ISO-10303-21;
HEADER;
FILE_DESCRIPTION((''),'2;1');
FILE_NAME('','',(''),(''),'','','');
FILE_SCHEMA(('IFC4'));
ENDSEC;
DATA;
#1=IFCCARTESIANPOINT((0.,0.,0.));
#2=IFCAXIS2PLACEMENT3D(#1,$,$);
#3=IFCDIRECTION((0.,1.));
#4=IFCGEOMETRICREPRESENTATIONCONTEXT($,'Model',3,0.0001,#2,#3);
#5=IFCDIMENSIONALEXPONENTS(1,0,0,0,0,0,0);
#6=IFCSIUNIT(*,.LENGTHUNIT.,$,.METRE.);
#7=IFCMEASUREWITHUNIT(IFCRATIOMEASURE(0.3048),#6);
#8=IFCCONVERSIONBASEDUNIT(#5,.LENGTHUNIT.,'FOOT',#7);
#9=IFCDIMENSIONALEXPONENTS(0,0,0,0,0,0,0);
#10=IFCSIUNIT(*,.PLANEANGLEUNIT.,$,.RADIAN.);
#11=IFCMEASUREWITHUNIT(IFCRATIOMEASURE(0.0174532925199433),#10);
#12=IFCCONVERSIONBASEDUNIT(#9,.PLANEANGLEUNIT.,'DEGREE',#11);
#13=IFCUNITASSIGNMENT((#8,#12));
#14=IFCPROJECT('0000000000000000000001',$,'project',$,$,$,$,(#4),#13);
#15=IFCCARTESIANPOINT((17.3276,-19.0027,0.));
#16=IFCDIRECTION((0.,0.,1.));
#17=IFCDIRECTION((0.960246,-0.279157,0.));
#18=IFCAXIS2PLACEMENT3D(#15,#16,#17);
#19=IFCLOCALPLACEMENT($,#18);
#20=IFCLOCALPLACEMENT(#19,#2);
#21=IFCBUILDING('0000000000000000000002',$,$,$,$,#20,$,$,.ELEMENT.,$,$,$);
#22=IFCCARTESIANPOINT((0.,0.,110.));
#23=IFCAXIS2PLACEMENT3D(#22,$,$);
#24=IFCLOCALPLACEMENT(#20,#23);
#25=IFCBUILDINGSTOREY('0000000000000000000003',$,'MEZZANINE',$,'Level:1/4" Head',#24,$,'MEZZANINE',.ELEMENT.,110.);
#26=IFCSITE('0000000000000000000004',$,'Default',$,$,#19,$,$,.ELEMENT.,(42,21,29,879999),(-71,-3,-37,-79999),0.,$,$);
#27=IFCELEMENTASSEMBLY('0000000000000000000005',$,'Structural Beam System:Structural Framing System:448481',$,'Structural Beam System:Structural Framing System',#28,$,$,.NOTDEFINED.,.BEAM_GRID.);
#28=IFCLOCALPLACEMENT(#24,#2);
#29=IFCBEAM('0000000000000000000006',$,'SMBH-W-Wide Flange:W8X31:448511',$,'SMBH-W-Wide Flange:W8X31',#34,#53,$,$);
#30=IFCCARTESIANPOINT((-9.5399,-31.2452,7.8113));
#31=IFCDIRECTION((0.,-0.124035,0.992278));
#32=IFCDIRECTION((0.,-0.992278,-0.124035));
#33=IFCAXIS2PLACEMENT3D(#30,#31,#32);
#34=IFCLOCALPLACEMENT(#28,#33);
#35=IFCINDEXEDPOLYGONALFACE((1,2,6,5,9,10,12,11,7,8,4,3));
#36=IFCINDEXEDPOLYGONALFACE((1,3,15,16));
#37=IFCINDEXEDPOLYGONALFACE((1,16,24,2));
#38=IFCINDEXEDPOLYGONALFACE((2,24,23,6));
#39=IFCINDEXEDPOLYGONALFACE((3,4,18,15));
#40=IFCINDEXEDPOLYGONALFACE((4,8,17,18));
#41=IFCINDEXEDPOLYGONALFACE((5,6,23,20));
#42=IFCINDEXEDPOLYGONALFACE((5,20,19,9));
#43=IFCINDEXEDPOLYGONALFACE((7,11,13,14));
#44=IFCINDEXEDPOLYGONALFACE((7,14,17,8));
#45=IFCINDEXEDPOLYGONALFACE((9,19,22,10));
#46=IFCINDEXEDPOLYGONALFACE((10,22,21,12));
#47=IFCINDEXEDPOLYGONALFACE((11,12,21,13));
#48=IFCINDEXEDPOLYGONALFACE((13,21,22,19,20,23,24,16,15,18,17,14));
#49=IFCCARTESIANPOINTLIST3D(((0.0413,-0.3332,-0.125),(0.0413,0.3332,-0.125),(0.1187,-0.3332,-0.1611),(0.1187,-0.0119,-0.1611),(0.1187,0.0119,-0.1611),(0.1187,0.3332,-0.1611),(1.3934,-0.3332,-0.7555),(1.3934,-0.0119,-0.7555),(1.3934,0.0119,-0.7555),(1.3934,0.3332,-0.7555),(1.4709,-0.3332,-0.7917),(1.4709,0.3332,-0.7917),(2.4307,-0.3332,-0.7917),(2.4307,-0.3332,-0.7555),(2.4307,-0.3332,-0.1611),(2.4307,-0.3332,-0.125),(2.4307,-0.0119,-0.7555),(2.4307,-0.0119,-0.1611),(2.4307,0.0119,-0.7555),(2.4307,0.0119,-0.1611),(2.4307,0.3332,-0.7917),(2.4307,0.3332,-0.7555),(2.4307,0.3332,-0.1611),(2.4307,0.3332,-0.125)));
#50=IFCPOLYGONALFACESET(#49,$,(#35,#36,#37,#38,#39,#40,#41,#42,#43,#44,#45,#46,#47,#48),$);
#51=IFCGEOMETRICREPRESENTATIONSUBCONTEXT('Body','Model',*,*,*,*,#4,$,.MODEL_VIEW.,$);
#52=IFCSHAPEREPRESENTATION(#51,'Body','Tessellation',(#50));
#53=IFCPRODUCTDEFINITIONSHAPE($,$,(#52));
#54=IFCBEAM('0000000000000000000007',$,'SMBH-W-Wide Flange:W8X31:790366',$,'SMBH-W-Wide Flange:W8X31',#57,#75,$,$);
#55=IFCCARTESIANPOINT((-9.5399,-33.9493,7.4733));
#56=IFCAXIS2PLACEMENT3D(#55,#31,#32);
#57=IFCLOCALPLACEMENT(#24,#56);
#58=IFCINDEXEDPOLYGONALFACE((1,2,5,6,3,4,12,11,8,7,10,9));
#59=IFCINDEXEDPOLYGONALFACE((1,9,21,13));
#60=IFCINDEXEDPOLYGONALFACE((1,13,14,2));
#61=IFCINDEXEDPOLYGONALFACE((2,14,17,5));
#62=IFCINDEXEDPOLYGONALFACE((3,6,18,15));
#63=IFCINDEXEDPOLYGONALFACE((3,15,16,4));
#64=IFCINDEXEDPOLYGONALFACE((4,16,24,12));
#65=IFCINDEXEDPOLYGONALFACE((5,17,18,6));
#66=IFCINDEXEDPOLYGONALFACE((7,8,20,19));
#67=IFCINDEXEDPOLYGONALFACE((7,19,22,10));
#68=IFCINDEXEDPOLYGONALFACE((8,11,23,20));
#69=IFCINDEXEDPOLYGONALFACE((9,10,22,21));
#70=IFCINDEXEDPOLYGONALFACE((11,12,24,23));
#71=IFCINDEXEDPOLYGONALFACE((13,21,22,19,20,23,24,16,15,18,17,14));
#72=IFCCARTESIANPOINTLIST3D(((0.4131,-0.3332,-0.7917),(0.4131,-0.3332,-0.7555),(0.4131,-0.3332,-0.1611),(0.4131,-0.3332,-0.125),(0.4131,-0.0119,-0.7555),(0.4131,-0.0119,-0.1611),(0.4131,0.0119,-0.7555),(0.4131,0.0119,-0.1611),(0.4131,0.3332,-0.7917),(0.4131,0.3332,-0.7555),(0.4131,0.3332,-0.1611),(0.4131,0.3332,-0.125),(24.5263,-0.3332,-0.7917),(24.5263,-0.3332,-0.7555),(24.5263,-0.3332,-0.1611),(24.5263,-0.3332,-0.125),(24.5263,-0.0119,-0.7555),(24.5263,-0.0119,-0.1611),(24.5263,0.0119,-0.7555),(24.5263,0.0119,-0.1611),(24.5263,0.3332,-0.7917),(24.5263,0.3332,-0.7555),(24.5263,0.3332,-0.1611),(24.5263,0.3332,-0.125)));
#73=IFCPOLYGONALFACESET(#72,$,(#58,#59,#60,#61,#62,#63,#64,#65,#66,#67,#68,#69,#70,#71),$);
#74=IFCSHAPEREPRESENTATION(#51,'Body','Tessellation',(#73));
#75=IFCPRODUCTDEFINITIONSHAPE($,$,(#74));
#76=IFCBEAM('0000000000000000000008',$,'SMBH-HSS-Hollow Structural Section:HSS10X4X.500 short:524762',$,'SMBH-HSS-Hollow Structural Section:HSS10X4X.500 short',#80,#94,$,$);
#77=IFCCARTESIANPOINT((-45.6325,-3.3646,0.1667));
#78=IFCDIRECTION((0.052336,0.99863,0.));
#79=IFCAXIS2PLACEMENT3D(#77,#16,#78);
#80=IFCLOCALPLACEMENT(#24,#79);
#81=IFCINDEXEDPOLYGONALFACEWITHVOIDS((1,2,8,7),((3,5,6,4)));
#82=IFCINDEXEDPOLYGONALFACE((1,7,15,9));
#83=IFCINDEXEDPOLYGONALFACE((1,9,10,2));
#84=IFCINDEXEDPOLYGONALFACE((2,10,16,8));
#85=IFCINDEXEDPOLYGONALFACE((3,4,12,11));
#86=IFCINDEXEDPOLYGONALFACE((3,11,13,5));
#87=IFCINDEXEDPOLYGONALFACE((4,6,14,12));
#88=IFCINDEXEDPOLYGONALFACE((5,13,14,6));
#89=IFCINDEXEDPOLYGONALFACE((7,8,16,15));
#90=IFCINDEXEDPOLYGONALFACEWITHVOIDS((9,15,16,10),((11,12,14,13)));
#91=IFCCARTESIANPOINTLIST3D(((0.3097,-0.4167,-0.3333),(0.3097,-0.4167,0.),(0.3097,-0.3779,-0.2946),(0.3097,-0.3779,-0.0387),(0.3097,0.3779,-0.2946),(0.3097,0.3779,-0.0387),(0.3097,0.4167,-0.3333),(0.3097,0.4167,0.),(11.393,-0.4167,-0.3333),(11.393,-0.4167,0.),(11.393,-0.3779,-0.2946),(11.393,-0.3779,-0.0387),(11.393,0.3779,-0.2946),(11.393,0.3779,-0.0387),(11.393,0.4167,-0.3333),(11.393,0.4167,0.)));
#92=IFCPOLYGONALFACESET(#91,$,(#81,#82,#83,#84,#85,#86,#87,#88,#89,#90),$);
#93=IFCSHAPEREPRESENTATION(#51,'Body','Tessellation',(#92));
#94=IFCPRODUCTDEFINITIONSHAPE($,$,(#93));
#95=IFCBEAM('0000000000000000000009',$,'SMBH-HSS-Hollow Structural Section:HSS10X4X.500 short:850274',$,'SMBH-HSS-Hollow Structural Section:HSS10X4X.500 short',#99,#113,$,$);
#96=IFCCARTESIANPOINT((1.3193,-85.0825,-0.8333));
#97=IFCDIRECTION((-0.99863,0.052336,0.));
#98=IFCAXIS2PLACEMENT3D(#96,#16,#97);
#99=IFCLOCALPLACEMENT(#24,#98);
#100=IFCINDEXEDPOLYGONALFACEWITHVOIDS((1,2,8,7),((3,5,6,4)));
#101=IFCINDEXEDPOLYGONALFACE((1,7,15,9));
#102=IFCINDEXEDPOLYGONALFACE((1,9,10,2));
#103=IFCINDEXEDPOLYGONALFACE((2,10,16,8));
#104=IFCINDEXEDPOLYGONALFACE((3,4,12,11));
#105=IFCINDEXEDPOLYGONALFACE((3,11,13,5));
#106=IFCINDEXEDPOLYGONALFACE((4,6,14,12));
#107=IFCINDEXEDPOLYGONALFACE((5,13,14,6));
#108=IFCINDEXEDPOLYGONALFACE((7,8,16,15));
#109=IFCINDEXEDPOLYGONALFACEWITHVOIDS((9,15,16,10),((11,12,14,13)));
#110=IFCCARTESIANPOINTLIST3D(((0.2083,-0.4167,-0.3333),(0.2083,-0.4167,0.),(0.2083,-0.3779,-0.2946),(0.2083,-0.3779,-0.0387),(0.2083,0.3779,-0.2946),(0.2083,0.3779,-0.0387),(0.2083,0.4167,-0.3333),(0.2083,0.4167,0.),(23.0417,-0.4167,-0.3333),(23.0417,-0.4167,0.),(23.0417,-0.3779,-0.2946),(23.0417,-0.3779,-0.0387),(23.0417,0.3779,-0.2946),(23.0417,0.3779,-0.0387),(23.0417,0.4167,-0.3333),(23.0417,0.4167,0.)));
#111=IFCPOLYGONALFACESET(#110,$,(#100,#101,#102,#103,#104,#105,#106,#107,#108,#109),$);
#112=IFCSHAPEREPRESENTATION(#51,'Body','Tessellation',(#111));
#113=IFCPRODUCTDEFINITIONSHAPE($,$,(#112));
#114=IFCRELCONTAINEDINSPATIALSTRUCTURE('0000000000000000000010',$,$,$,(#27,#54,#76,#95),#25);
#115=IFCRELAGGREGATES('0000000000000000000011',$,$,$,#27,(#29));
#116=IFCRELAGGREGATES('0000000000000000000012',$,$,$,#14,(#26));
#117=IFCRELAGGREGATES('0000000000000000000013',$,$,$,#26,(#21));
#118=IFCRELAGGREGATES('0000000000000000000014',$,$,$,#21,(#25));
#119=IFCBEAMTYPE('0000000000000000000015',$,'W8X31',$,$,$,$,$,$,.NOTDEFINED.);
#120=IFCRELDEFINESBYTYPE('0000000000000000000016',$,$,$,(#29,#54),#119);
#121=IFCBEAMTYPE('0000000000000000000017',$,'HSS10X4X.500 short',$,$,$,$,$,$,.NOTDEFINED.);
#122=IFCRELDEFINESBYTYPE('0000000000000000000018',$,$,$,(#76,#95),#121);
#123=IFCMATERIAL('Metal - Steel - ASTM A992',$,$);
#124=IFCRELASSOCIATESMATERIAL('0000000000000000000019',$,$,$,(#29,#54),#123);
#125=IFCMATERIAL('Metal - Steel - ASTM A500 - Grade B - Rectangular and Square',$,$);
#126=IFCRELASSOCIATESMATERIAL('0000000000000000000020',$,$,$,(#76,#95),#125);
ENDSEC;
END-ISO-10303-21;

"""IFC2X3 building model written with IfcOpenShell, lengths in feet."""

from ifc_helpers import new_model, entity, si_unit, converted_unit, direction, frame, frame_2d, origin, place, context, subcontext, project, spatial, rectangle, i_section, extrude, boolean, clip, halfspace, material, type_object, element, aggregate, save


model = new_model("IFC2X3")

# Units and contexts
model_context = context("Model", 3, precision=0.0001, world=origin(), true_north=direction((0.0, 1.0)))
body_context = subcontext(model_context, "Body", "Model", "MODEL_VIEW")
ifc_project = project(units=[converted_unit("LENGTHUNIT", "FOOT", entity("IfcRatioMeasure", 0.3048), si_unit("LENGTHUNIT", "METRE"), dimensions=[1, 0, 0, 0, 0, 0, 0]), converted_unit("PLANEANGLEUNIT", "DEGREE", entity("IfcRatioMeasure", 0.0174532925199433), si_unit("PLANEANGLEUNIT", "RADIAN"), dimensions=[0, 0, 0, 0, 0, 0, 0])], contexts=[model_context])

# Site, building, storey
site_placement = place(None, frame((17.3276, -19.0027, 0.0), z_axis=(0.0, 0.0, 1.0), x_axis=(0.960246, -0.279157, 0.0)))
site = spatial("IfcSite", under=ifc_project, at=site_placement, Name="Default", CompositionType="ELEMENT", RefLatitude=(42, 21, 29, 879999), RefLongitude=(-71, -3, -37, -79999), RefElevation=0.0)
building_placement = place(site_placement, origin())
building = spatial("IfcBuilding", under=site, at=building_placement, CompositionType="ELEMENT")
storey_placement = place(building_placement, frame((0.0, 0.0, 110.0)))
storey = spatial("IfcBuildingStorey", under=building, at=storey_placement, Name="MEZZANINE", ObjectType="Level:1/4\" Head", LongName="MEZZANINE", CompositionType="ELEMENT", Elevation=110.0)

# Shared definitions
ifc_material_1 = material(Name="Metal - Steel - ASTM A500 - Grade B - Rectangular and Square")

# Element assembly, beam
assembly_1_placement = place(storey_placement, origin())
assembly_1 = element("IfcElementAssembly", 1, at=assembly_1_placement, inside=storey, Name="Structural Beam System:Structural Framing System:448481", ObjectType="Structural Beam System:Structural Framing System", AssemblyPlace="NOTDEFINED", PredefinedType="BEAM_GRID")
ifc_material_2 = material(Name="Metal - Steel - ASTM A992")
beam_type_1 = type_object("IfcBeamType", Name="W8X31", PredefinedType="NOTDEFINED")
beam_1_placement = place(assembly_1_placement, frame((-9.5399, -31.2452, 7.8113), z_axis=(0.0, -0.124035, 0.992278), x_axis=(0.0, -0.992278, -0.124035)))
beam_1 = element("IfcBeam", 2, at=beam_1_placement, type_object=beam_type_1, material=ifc_material_2, Name="SMBH-W-Wide Flange:W8X31:448511", ObjectType="SMBH-W-Wide Flange:W8X31", context=body_context, shape_type="SweptSolid", body=[
    clip(extrude(i_section(OverallWidth=0.6663, OverallDepth=0.6667, WebThickness=0.0238, FlangeThickness=0.0361, at=frame_2d((0.0, 0.0), x_axis=(0.0, 1.0))), frame((0.0413, 0.0, -0.4583), z_axis=(1.0, 0.0, 0.0), x_axis=(0.0, 0.0, -1.0)), (0.0, 0.0, 1.0), 2.3894), halfspace(frame((1.4709, -2.7251, -0.7917), z_axis=(-0.422618, 0.0, -0.906308), x_axis=(0.0, 1.0, 0.0)), False)),
])
aggregate(assembly_1, [beam_1])

# Beams
beam_2_placement = place(storey_placement, frame((-9.5399, -33.9493, 7.4733), z_axis=(0.0, -0.124035, 0.992278), x_axis=(0.0, -0.992278, -0.124035)))
element("IfcBeam", 3, at=beam_2_placement, inside=storey, type_object=beam_type_1, material=ifc_material_2, Name="SMBH-W-Wide Flange:W8X31:790366", ObjectType="SMBH-W-Wide Flange:W8X31", context=body_context, shape_type="SweptSolid", body=[
    extrude(i_section(OverallWidth=0.6663, OverallDepth=0.6667, WebThickness=0.0238, FlangeThickness=0.0361, at=frame_2d((0.0, 0.0), x_axis=(0.0, 1.0))), frame((0.4131, 0.0, -0.4583), z_axis=(1.0, 0.0, 0.0), x_axis=(0.0, 0.0, -1.0)), (0.0, 0.0, 1.0), 24.1132),
])
beam_type_2 = type_object("IfcBeamType", Name="HSS10X4X.500 short", PredefinedType="NOTDEFINED")
beam_3_placement = place(storey_placement, frame((-45.6325, -3.3646, 0.1667), z_axis=(0.0, 0.0, 1.0), x_axis=(0.052336, 0.99863, 0.0)))
element("IfcBeam", 4, at=beam_3_placement, inside=storey, type_object=beam_type_2, material=ifc_material_1, Name="SMBH-HSS-Hollow Structural Section:HSS10X4X.500 short:524762", ObjectType="SMBH-HSS-Hollow Structural Section:HSS10X4X.500 short", context=body_context, shape_type="SweptSolid", body=[
    boolean("DIFFERENCE", extrude(rectangle(XDim=0.3333, YDim=0.8333, at=frame_2d((0.0, 0.0), x_axis=(1.0, 0.0))), frame((0.3097, 0.0, -0.1667), z_axis=(1.0, 0.0, 0.0), x_axis=(0.0, 0.0, -1.0)), (0.0, 0.0, 1.0), 11.0833), extrude(rectangle(XDim=0.2559, YDim=0.7559, at=frame_2d((0.0, 0.0), x_axis=(0.0, 1.0))), frame((11.393, 0.0, -0.1667), z_axis=(-1.0, 0.0, 0.0), x_axis=(0.0, 1.0, 0.0)), (0.0, 0.0, 1.0), 11.0833)),
])
beam_4_placement = place(storey_placement, frame((1.3193, -85.0825, -0.8333), z_axis=(0.0, 0.0, 1.0), x_axis=(-0.99863, 0.052336, 0.0)))
element("IfcBeam", 5, at=beam_4_placement, inside=storey, type_object=beam_type_2, material=ifc_material_1, Name="SMBH-HSS-Hollow Structural Section:HSS10X4X.500 short:850274", ObjectType="SMBH-HSS-Hollow Structural Section:HSS10X4X.500 short", context=body_context, shape_type="SweptSolid", body=[
    boolean("DIFFERENCE", extrude(rectangle(XDim=0.3333, YDim=0.8333, at=frame_2d((0.0, 0.0), x_axis=(1.0, 0.0))), frame((0.2083, 0.0, -0.1667), z_axis=(1.0, 0.0, 0.0), x_axis=(0.0, 0.0, -1.0)), (0.0, 0.0, 1.0), 22.8333), extrude(rectangle(XDim=0.2559, YDim=0.7559, at=frame_2d((0.0, 0.0), x_axis=(0.0, 1.0))), frame((23.0417, 0.0, -0.1667), z_axis=(-1.0, 0.0, 0.0), x_axis=(0.0, 1.0, 0.0)), (0.0, 0.0, 1.0), 22.8333)),
])

save(model, "model.ifc")
